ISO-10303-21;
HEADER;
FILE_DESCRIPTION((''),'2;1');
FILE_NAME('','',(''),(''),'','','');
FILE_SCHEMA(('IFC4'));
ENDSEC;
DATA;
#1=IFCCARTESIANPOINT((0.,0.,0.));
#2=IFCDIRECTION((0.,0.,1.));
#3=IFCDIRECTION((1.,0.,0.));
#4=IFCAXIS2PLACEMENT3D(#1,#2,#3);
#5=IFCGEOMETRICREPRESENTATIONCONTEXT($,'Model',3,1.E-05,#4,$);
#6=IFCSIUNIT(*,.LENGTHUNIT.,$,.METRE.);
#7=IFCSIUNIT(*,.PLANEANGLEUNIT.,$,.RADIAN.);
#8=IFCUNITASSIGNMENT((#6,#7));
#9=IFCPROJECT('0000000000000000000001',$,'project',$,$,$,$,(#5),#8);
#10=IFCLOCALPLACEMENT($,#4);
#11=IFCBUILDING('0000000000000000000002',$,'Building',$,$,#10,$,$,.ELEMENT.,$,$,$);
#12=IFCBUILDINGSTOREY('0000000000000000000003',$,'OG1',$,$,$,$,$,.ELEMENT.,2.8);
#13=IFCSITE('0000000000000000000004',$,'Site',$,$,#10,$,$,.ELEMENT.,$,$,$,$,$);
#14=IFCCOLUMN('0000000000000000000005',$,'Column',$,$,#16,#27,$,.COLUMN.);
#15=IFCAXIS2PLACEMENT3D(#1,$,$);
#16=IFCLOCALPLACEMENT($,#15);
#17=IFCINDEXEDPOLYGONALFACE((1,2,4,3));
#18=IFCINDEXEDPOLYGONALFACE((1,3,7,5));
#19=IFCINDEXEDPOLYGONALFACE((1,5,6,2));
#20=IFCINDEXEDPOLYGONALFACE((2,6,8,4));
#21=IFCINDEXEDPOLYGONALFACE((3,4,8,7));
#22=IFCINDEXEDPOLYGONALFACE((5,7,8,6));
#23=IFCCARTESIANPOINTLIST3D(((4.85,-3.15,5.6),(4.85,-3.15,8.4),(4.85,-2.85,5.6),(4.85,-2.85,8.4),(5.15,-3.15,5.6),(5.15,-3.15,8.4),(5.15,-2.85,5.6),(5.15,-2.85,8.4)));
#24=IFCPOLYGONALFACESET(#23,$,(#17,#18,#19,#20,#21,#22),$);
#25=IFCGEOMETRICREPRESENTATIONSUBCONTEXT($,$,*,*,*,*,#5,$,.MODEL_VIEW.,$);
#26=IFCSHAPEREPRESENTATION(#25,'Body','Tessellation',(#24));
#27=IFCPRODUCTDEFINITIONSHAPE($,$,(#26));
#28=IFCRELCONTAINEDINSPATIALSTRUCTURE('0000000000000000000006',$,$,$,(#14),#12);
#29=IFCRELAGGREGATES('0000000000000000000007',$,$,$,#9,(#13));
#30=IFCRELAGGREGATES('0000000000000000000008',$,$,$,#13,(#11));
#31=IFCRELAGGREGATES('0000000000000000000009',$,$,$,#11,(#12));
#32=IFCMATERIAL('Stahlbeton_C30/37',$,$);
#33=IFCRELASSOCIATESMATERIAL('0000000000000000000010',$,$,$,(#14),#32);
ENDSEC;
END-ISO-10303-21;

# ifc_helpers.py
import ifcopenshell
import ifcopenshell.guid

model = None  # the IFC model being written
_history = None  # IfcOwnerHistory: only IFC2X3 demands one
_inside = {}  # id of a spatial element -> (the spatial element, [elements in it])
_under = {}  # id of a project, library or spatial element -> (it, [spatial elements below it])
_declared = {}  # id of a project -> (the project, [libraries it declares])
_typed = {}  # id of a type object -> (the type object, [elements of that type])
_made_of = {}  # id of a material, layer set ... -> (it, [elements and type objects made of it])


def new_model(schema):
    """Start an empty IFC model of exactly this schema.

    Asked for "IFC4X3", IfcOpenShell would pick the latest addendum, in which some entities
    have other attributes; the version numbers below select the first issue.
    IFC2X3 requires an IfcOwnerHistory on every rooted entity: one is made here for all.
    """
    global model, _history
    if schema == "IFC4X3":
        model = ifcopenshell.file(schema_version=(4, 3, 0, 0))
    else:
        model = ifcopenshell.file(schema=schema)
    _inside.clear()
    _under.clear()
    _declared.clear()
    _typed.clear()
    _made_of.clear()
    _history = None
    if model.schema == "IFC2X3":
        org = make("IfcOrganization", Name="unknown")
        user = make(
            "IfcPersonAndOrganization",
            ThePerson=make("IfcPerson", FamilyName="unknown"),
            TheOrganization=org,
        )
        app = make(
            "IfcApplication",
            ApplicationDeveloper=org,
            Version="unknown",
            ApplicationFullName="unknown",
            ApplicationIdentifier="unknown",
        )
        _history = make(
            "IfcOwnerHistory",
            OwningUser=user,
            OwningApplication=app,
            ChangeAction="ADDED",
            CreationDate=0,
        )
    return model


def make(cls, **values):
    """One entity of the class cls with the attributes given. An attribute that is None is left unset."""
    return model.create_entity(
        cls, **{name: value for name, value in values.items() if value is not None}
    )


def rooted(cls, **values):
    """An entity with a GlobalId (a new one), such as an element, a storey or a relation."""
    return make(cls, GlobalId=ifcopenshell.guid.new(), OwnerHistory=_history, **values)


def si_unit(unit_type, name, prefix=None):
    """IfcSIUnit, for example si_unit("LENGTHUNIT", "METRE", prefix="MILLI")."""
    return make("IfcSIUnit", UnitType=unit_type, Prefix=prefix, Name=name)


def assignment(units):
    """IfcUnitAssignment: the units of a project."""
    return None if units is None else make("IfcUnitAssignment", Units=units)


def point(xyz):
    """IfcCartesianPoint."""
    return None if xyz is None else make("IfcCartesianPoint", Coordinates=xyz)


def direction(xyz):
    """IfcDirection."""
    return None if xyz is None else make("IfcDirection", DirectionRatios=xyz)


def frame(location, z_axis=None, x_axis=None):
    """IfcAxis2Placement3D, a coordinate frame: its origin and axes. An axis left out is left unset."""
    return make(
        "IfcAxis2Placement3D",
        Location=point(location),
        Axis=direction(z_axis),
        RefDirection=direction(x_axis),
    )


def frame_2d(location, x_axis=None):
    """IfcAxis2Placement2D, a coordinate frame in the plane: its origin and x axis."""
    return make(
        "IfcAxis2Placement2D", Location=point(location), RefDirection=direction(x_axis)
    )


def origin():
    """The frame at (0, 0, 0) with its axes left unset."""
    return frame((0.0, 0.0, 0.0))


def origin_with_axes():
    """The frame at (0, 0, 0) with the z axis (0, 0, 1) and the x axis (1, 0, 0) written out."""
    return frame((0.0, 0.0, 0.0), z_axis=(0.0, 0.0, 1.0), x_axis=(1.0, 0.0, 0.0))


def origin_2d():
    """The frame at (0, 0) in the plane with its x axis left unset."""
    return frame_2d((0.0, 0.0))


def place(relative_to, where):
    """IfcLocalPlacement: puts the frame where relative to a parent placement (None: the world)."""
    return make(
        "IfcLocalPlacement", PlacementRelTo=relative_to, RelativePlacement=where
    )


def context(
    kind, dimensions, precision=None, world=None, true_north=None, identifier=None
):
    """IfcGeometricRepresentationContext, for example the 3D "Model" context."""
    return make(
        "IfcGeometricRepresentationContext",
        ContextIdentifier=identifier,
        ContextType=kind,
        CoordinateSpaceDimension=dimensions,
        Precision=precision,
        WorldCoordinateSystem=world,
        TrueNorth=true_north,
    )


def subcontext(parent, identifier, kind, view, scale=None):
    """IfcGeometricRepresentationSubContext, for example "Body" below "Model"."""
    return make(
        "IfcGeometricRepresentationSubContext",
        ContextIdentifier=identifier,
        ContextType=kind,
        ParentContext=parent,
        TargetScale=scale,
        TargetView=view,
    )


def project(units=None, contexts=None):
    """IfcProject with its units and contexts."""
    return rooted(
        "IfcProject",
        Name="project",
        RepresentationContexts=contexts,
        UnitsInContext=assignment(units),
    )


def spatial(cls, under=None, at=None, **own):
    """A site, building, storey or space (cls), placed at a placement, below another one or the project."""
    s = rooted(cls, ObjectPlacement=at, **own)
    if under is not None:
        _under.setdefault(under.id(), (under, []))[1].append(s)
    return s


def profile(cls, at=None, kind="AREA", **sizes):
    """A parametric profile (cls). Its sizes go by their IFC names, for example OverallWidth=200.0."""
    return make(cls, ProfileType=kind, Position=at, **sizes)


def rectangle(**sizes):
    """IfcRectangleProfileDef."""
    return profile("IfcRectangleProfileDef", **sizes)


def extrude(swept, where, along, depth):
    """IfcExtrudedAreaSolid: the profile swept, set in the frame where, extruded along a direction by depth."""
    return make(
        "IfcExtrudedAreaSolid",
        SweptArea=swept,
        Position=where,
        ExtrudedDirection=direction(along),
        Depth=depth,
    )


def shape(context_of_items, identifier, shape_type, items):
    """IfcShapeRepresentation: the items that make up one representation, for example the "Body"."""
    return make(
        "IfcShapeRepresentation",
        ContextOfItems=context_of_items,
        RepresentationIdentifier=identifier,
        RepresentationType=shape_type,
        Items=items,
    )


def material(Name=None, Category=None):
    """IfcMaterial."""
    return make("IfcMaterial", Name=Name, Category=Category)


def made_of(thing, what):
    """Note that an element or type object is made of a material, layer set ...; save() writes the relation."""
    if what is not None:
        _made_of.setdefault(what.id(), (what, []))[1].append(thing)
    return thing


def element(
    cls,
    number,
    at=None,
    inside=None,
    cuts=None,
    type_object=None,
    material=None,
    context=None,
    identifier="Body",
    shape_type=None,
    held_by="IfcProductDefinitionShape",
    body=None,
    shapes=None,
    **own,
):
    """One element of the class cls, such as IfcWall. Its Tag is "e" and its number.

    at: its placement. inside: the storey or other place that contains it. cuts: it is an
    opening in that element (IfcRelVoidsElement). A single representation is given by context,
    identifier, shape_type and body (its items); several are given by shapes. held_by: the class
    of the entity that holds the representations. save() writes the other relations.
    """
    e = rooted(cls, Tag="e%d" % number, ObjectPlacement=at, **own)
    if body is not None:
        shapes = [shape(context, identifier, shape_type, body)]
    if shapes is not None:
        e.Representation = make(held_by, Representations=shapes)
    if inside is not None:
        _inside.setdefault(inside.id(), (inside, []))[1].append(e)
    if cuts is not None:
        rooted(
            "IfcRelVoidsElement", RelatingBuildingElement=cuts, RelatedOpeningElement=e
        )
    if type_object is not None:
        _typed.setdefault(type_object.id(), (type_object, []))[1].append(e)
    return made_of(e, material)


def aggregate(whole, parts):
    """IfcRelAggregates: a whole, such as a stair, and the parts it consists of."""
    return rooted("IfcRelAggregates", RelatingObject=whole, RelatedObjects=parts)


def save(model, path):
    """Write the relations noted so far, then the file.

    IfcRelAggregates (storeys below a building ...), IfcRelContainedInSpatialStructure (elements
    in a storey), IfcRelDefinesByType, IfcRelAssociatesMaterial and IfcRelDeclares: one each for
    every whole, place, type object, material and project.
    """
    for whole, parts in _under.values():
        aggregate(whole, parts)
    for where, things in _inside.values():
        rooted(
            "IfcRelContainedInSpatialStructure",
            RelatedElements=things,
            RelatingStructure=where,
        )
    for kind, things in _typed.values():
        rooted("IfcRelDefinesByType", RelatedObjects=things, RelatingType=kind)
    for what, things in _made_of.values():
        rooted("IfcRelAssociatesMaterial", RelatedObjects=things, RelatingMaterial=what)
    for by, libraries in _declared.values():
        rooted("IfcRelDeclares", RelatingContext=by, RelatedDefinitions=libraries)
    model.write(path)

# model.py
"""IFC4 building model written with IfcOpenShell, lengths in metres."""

from ifc_helpers import new_model, si_unit, frame, origin, origin_with_axes, origin_2d, place, context, subcontext, project, spatial, rectangle, extrude, material, element, save


model = new_model("IFC4")

# Units and contexts
model_context = context("Model", 3, precision=1e-05, world=origin_with_axes())
sub_context = subcontext(model_context, None, None, "MODEL_VIEW")
ifc_project = project(units=[si_unit("LENGTHUNIT", "METRE"), si_unit("PLANEANGLEUNIT", "RADIAN")], contexts=[model_context])

# Site, building, storey
placement_1 = place(None, origin_with_axes())
site = spatial("IfcSite", under=ifc_project, at=placement_1, Name="Site", CompositionType="ELEMENT")
building = spatial("IfcBuilding", under=site, at=placement_1, Name="Building", CompositionType="ELEMENT")
storey = spatial("IfcBuildingStorey", under=building, Name="OG1", CompositionType="ELEMENT", Elevation=2.8)

# Column
ifc_material = material(Name="Stahlbeton_C30/37")
placement_2 = place(None, origin_with_axes())
placement_3 = place(placement_2, frame((0.0, 0.0, 2.8)))
column_placement = place(placement_3, frame((5.0, -3.0, 2.8)))
element("IfcColumn", 1, at=column_placement, inside=storey, material=ifc_material, Name="Column", PredefinedType="COLUMN", context=sub_context, shape_type="SweptSolid", body=[
    extrude(rectangle(XDim=0.3, YDim=0.3, at=origin_2d()), origin(), (0.0, 0.0, 1.0), 2.8),
])

save(model, "model.ifc")
